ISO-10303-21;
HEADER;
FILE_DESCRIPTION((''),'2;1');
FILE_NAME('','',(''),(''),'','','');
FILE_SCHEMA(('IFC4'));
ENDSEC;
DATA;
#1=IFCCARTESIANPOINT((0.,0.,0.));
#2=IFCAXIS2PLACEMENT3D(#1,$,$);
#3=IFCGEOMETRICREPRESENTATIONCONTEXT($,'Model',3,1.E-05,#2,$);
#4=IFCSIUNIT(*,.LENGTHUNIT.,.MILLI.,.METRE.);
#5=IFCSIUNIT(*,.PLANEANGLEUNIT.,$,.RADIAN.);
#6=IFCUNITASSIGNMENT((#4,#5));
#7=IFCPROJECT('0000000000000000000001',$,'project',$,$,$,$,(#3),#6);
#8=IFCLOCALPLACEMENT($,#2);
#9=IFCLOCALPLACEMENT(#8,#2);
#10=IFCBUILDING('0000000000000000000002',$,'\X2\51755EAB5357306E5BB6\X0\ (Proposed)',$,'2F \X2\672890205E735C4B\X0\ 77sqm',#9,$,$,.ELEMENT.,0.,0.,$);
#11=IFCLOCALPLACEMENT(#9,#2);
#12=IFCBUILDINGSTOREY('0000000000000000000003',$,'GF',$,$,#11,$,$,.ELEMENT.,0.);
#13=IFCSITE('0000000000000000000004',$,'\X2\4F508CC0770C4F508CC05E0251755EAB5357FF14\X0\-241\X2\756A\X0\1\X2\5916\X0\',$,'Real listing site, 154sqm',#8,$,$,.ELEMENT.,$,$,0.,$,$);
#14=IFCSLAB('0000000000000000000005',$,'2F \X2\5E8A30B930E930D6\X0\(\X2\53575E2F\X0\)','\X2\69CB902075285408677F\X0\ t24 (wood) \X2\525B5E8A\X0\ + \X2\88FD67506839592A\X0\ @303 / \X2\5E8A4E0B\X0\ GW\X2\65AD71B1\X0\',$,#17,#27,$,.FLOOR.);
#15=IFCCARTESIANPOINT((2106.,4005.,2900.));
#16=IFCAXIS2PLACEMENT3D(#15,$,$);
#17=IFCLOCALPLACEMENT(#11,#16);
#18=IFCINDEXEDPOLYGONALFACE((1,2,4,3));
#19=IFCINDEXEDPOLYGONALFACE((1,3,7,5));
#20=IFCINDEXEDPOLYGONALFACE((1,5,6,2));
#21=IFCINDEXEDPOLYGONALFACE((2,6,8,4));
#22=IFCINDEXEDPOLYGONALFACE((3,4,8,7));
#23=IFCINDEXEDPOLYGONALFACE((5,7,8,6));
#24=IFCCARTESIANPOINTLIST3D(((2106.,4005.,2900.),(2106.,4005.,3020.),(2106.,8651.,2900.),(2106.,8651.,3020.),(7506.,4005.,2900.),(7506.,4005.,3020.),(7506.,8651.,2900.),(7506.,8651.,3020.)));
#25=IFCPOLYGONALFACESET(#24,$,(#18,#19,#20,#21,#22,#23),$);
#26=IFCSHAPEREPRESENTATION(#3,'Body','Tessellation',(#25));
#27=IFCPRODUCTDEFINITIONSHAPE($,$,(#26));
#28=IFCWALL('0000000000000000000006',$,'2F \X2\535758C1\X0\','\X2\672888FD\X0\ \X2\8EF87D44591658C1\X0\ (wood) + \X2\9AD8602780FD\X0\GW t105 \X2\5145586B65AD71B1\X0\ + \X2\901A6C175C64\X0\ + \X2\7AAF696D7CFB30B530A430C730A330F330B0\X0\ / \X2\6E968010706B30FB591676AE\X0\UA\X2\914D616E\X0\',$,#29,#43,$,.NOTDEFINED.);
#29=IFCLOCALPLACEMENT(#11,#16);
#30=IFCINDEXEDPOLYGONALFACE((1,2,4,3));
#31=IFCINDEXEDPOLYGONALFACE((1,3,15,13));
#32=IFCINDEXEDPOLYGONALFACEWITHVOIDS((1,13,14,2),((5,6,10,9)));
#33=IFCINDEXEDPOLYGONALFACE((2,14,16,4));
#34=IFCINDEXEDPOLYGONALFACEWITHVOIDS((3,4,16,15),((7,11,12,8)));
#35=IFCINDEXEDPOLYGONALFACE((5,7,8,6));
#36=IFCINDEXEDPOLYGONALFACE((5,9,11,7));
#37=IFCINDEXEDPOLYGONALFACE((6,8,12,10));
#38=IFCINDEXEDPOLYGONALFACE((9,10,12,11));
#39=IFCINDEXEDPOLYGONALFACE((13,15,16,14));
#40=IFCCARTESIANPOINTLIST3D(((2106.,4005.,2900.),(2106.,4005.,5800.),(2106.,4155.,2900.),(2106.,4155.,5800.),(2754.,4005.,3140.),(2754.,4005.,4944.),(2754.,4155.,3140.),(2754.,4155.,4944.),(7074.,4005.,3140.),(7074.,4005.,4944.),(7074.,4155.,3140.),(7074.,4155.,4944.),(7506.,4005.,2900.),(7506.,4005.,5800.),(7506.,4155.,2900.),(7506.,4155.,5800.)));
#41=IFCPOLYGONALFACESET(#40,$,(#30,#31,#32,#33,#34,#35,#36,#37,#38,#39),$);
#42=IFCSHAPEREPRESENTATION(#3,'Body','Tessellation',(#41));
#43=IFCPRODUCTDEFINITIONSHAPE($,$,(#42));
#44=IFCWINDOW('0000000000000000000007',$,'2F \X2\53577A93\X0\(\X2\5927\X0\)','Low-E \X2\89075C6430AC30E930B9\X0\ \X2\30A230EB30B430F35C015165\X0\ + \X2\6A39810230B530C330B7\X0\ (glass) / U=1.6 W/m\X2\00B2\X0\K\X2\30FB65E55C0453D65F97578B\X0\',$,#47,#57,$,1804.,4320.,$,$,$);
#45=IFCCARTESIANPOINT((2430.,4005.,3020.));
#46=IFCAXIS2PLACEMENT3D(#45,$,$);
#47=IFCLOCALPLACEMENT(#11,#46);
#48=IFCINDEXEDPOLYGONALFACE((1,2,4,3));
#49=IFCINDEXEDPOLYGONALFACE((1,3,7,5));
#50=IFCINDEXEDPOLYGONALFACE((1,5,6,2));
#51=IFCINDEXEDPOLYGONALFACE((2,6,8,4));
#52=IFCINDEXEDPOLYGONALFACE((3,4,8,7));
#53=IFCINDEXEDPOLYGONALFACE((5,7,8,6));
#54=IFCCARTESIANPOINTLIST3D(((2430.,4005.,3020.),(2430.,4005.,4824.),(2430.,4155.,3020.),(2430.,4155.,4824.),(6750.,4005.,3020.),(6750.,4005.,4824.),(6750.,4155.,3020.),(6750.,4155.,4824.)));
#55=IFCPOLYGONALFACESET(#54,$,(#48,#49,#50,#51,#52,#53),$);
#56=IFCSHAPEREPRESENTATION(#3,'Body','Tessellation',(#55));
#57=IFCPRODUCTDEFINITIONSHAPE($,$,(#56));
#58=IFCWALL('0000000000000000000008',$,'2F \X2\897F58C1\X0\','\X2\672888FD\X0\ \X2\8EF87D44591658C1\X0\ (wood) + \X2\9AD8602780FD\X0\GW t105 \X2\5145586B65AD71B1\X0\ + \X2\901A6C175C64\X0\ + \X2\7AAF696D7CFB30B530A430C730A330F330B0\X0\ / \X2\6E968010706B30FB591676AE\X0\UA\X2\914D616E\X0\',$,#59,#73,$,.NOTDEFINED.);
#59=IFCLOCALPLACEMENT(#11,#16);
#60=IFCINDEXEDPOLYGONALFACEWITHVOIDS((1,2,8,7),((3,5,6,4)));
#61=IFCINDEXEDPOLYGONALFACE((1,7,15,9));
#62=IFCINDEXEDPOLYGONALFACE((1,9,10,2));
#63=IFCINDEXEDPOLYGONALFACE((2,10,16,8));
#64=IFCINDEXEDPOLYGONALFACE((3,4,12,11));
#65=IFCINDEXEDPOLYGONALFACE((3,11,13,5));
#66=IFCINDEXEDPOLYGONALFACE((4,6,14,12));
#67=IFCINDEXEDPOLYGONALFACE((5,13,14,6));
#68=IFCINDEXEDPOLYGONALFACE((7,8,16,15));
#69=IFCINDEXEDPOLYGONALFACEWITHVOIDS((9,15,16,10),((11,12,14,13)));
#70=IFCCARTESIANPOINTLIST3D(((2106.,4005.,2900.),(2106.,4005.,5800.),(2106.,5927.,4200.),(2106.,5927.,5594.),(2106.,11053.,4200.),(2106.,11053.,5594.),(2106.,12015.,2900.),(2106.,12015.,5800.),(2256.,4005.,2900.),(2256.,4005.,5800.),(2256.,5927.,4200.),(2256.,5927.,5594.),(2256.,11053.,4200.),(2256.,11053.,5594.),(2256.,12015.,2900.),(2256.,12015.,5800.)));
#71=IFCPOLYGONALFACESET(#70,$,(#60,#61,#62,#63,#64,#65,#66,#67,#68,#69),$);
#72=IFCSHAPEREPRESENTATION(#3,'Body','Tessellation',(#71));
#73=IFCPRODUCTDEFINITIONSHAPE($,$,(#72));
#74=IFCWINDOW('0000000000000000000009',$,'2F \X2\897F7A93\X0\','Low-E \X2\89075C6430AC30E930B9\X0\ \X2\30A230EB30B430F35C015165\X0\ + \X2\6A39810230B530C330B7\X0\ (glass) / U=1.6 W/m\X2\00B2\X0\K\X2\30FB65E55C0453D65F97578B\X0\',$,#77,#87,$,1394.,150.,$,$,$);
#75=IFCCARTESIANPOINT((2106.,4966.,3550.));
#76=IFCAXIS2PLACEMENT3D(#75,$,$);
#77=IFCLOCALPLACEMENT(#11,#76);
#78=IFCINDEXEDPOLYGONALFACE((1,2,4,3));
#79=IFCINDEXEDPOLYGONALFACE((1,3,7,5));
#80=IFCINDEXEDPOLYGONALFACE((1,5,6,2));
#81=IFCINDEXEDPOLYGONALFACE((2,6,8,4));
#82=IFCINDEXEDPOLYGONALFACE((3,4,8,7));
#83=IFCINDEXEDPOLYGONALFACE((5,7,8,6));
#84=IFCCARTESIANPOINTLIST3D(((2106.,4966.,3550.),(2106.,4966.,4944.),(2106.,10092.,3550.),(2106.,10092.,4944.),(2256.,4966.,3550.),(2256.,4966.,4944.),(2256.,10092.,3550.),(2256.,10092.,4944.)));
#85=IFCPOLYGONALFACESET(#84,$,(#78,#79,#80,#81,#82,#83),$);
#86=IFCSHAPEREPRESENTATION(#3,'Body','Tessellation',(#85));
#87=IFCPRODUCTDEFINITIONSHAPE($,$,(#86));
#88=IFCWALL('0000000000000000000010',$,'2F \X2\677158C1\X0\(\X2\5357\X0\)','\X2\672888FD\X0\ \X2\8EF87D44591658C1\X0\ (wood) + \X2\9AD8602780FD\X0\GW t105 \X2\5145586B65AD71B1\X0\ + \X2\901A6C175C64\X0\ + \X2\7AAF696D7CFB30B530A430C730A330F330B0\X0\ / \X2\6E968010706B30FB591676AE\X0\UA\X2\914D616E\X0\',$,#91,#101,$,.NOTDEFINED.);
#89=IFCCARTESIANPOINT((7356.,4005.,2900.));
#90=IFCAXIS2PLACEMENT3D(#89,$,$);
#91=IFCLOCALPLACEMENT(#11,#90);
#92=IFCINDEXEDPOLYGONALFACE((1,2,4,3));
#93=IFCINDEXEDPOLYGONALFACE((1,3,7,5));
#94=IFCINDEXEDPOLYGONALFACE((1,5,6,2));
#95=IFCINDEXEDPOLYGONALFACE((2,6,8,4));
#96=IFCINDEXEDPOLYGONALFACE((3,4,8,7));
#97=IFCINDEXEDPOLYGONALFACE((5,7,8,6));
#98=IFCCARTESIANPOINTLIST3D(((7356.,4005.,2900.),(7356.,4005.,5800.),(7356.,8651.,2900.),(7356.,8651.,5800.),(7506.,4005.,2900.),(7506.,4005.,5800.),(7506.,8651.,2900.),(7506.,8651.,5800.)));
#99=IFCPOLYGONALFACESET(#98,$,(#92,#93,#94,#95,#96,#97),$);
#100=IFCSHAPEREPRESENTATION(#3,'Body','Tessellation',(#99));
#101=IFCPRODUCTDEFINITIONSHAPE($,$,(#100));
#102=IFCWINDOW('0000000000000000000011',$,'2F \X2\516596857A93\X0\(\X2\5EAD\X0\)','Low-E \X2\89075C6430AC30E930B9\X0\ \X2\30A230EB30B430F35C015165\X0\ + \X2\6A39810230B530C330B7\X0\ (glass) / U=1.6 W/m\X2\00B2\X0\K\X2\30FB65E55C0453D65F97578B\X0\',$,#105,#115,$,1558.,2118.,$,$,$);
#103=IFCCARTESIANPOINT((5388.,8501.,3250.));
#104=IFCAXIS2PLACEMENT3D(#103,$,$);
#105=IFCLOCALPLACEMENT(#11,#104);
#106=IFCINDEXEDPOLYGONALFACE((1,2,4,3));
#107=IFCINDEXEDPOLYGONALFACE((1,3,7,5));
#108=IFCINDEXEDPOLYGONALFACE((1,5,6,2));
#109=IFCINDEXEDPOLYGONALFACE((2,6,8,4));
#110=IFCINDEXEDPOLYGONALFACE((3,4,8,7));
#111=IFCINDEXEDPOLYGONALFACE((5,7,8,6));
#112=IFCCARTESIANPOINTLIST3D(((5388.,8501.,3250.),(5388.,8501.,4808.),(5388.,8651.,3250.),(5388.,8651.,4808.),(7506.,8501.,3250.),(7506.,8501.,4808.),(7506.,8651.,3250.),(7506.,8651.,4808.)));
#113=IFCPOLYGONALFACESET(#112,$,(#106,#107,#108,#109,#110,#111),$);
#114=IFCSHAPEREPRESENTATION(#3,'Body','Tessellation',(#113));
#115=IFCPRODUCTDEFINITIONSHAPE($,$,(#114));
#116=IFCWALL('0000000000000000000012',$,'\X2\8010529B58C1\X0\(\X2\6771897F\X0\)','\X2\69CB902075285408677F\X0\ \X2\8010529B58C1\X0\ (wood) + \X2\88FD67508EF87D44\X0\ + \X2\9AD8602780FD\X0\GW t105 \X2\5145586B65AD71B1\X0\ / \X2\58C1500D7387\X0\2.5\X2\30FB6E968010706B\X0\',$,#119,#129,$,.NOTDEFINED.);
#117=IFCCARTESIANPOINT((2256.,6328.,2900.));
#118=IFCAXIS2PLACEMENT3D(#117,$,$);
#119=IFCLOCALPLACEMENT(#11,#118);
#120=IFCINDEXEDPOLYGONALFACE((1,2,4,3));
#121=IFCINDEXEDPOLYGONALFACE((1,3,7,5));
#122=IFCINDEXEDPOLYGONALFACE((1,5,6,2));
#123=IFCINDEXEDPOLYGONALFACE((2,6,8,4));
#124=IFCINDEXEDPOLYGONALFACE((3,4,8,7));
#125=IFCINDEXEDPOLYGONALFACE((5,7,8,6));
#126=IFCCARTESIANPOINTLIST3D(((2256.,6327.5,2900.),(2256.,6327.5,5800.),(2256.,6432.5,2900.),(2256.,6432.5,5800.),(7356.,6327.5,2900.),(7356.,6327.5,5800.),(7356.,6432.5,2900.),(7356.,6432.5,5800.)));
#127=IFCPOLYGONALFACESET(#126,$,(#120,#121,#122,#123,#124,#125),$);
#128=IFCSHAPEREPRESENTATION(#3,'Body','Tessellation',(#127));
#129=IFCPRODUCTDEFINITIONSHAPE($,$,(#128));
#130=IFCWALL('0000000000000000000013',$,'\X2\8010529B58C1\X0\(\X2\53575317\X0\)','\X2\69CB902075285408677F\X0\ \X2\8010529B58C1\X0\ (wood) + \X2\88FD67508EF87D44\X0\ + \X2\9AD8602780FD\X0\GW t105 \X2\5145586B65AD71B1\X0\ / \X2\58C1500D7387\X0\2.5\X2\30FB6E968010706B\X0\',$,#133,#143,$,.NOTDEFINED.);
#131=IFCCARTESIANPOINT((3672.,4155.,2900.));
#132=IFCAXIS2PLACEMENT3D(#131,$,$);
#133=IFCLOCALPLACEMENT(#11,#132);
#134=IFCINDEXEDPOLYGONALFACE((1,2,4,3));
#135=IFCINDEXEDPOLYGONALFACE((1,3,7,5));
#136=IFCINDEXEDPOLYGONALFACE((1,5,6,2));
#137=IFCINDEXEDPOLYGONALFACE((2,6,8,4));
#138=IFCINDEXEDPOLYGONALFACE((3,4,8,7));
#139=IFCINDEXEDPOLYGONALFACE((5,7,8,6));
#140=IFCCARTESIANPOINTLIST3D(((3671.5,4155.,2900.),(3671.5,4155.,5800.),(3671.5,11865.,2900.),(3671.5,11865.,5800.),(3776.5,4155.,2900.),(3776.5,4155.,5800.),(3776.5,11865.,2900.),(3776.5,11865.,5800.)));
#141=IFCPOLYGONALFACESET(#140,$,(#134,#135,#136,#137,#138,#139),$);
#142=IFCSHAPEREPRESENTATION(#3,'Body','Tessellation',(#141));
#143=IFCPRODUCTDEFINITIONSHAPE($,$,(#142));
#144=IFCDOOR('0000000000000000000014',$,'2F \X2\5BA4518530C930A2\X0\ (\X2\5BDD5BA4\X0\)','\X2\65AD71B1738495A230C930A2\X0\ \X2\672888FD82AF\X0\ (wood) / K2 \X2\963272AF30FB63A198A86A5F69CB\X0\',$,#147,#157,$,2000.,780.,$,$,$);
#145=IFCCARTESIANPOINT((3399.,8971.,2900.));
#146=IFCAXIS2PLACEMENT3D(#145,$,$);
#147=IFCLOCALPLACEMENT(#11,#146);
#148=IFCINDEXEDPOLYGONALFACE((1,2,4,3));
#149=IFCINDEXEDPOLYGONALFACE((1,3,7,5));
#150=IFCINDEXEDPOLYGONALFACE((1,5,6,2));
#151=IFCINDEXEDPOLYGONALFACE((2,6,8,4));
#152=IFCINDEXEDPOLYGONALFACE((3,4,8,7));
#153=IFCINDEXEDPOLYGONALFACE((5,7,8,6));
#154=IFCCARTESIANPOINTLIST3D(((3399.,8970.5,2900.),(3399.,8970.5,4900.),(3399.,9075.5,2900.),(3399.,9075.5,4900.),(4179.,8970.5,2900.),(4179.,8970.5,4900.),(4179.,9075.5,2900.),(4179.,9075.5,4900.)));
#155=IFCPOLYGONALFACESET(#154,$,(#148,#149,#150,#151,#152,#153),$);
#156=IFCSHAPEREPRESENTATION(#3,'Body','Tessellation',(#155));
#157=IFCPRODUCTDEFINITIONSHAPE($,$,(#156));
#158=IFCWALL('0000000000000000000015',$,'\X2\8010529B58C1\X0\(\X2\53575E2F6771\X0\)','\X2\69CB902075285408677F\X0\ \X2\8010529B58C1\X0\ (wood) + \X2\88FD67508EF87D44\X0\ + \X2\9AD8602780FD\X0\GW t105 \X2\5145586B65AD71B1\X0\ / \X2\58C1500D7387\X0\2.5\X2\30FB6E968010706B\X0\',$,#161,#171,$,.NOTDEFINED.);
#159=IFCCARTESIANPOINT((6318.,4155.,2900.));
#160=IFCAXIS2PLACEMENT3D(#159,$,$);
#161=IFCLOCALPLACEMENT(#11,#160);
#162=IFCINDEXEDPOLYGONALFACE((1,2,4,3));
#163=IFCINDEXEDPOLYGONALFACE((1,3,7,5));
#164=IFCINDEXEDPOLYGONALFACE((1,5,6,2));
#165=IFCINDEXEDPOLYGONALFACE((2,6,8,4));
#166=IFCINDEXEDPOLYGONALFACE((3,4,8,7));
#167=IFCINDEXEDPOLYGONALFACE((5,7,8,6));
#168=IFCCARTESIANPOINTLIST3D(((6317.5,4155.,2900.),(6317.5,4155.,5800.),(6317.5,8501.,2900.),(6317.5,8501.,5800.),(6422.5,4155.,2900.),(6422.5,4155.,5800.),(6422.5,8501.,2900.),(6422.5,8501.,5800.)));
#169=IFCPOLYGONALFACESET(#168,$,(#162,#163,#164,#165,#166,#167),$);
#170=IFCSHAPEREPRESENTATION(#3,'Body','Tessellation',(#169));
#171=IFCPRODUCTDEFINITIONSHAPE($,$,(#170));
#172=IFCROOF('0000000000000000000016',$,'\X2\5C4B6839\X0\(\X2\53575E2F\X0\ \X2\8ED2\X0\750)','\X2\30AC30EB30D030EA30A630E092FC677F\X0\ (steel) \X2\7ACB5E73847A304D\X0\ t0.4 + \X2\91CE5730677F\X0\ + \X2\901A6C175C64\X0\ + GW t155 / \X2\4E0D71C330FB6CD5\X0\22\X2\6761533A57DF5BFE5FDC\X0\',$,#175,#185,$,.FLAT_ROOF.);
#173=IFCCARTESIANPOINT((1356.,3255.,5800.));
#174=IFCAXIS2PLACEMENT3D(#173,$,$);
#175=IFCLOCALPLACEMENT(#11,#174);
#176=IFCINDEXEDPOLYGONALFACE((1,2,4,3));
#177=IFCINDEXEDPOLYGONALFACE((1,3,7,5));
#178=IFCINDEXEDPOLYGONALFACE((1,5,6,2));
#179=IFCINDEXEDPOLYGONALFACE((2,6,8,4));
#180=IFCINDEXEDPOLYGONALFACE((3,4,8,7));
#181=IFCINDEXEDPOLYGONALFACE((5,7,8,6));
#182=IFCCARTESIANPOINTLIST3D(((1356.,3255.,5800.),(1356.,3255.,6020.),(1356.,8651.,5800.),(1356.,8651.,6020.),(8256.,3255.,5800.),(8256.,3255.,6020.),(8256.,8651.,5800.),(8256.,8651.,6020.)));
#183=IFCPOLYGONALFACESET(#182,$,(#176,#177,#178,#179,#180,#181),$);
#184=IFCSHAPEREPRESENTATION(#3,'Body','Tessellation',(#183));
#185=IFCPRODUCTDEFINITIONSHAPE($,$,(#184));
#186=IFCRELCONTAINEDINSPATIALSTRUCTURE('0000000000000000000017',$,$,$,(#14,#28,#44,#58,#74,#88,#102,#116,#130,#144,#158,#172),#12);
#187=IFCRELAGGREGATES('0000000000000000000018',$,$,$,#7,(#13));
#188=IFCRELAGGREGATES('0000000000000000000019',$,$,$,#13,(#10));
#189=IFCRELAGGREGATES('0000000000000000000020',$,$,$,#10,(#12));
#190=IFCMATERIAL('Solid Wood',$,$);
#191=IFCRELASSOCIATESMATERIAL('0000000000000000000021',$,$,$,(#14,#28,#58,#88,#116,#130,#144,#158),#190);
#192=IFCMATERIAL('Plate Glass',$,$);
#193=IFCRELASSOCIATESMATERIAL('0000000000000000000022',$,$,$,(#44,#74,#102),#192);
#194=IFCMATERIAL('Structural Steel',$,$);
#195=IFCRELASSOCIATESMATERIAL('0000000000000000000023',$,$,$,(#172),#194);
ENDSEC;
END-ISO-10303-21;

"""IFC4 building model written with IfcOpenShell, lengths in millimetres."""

from ifc_helpers import new_model, si_unit, frame, frame_2d, origin, place, context, project, spatial, rectangle, extrude, material, element, fill, save


model = new_model("IFC4")

# Units and contexts
model_context = context("Model", 3, precision=1e-05, world=origin())
ifc_project = project(units=[si_unit("LENGTHUNIT", "METRE", prefix="MILLI"), si_unit("PLANEANGLEUNIT", "RADIAN")], contexts=[model_context])

# Site, building, storey
site_placement = place(None, origin())
site = spatial("IfcSite", under=ifc_project, at=site_placement, Name="佐賀県佐賀市兵庫南４-241番1外", ObjectType="Real listing site, 154sqm", CompositionType="ELEMENT", RefElevation=0.0)
building_placement = place(site_placement, origin())
building = spatial("IfcBuilding", under=site, at=building_placement, Name="兵庫南の家 (Proposed)", ObjectType="2F 木造平屋 77sqm", CompositionType="ELEMENT", ElevationOfRefHeight=0.0, ElevationOfTerrain=0.0)
storey_placement = place(building_placement, origin())
storey = spatial("IfcBuildingStorey", under=building, at=storey_placement, Name="GF", CompositionType="ELEMENT", Elevation=0.0)

# Slab
ifc_material_1 = material(Name="Solid Wood")
slab_placement = place(storey_placement, frame((2106.0, 4005.0, 2900.0)))
element("IfcSlab", 1, at=slab_placement, inside=storey, material=ifc_material_1, Name="2F 床スラブ(南帯)", Description="構造用合板 t24 (wood) 剛床 + 製材根太 @303 / 床下 GW断熱", PredefinedType="FLOOR", context=model_context, shape_type="SweptSolid", body=[
    extrude(rectangle(XDim=5400.0, YDim=4646.0, at=frame_2d((2700.0, 2323.0))), frame((2106.0, 4005.0, 2900.0)), (0.0, 0.0, 1.0), 120.0),
])

# Walls, openings, windows
wall_1_placement = place(storey_placement, frame((2106.0, 4005.0, 2900.0)))
wall_1 = element("IfcWall", 2, at=wall_1_placement, inside=storey, material=ifc_material_1, Name="2F 南壁", Description="木製 軸組外壁 (wood) + 高性能GW t105 充填断熱 + 通気層 + 窯業系サイディング / 準耐火・外皮UA配慮", PredefinedType="NOTDEFINED", context=model_context, shape_type="SweptSolid", body=[
    extrude(rectangle(XDim=5400.0, YDim=150.0, at=frame_2d((2700.0, 75.0))), frame((2106.0, 4005.0, 2900.0)), (0.0, 0.0, 1.0), 2900.0),
])
opening_1_placement = place(storey_placement, frame((2430.0, 4005.0, 3020.0)))
opening_1 = element("IfcOpeningElement", 3, at=opening_1_placement, cuts=wall_1, PredefinedType="NOTDEFINED", context=model_context, shape_type="SweptSolid", body=[
    extrude(rectangle(XDim=4320.0, YDim=150.0, at=frame_2d((2160.0, 75.0))), frame((2430.0, 4005.0, 3020.0)), (0.0, 0.0, 1.0), 1804.0),
])
ifc_material_2 = material(Name="Plate Glass")
window_1_placement = place(storey_placement, frame((2430.0, 4005.0, 3020.0)))
window_1 = element("IfcWindow", 4, at=window_1_placement, inside=storey, material=ifc_material_2, Name="2F 南窓(大)", Description="Low-E 複層ガラス アルゴン封入 + 樹脂サッシ (glass) / U=1.6 W/m²K・日射取得型", OverallHeight=1804.0, OverallWidth=4320.0, context=model_context, shape_type="SweptSolid", body=[
    extrude(rectangle(XDim=4320.0, YDim=150.0, at=frame_2d((2160.0, 75.0))), frame((2430.0, 4005.0, 3020.0)), (0.0, 0.0, 1.0), 1804.0),
])
fill(opening_1, window_1)
wall_2_placement = place(storey_placement, frame((2106.0, 4005.0, 2900.0)))
wall_2 = element("IfcWall", 5, at=wall_2_placement, inside=storey, material=ifc_material_1, Name="2F 西壁", Description="木製 軸組外壁 (wood) + 高性能GW t105 充填断熱 + 通気層 + 窯業系サイディング / 準耐火・外皮UA配慮", PredefinedType="NOTDEFINED", context=model_context, shape_type="SweptSolid", body=[
    extrude(rectangle(XDim=150.0, YDim=8010.0, at=frame_2d((75.0, 4005.0))), frame((2106.0, 4005.0, 2900.0)), (0.0, 0.0, 1.0), 2900.0),
])
opening_2_placement = place(storey_placement, frame((2106.0, 4966.0, 3550.0)))
opening_2 = element("IfcOpeningElement", 6, at=opening_2_placement, cuts=wall_2, PredefinedType="NOTDEFINED", context=model_context, shape_type="SweptSolid", body=[
    extrude(rectangle(XDim=150.0, YDim=5126.0, at=frame_2d((75.0, 2563.0))), frame((2106.0, 4966.0, 3550.0)), (0.0, 0.0, 1.0), 1394.0),
])
window_2_placement = place(storey_placement, frame((2106.0, 4966.0, 3550.0)))
window_2 = element("IfcWindow", 7, at=window_2_placement, inside=storey, material=ifc_material_2, Name="2F 西窓", Description="Low-E 複層ガラス アルゴン封入 + 樹脂サッシ (glass) / U=1.6 W/m²K・日射取得型", OverallHeight=1394.0, OverallWidth=150.0, context=model_context, shape_type="SweptSolid", body=[
    extrude(rectangle(XDim=150.0, YDim=5126.0, at=frame_2d((75.0, 2563.0))), frame((2106.0, 4966.0, 3550.0)), (0.0, 0.0, 1.0), 1394.0),
])
fill(opening_2, window_2)
wall_3_placement = place(storey_placement, frame((7356.0, 4005.0, 2900.0)))
wall_3 = element("IfcWall", 8, at=wall_3_placement, inside=storey, material=ifc_material_1, Name="2F 東壁(南)", Description="木製 軸組外壁 (wood) + 高性能GW t105 充填断熱 + 通気層 + 窯業系サイディング / 準耐火・外皮UA配慮", PredefinedType="NOTDEFINED", context=model_context, shape_type="SweptSolid", body=[
    extrude(rectangle(XDim=150.0, YDim=4646.0, at=frame_2d((75.0, 2323.0))), frame((7356.0, 4005.0, 2900.0)), (0.0, 0.0, 1.0), 2900.0),
])
opening_3_placement = place(storey_placement, frame((5388.0, 8501.0, 3250.0)))
opening_3 = element("IfcOpeningElement", 9, at=opening_3_placement, cuts=wall_3, PredefinedType="NOTDEFINED", context=model_context, shape_type="SweptSolid", body=[
    extrude(rectangle(XDim=2118.0, YDim=150.0, at=frame_2d((1059.0, 75.0))), frame((5388.0, 8501.0, 3250.0)), (0.0, 0.0, 1.0), 1558.0),
])
window_3_placement = place(storey_placement, frame((5388.0, 8501.0, 3250.0)))
window_3 = element("IfcWindow", 10, at=window_3_placement, inside=storey, material=ifc_material_2, Name="2F 入隅窓(庭)", Description="Low-E 複層ガラス アルゴン封入 + 樹脂サッシ (glass) / U=1.6 W/m²K・日射取得型", OverallHeight=1558.0, OverallWidth=2118.0, context=model_context, shape_type="SweptSolid", body=[
    extrude(rectangle(XDim=2118.0, YDim=150.0, at=frame_2d((1059.0, 75.0))), frame((5388.0, 8501.0, 3250.0)), (0.0, 0.0, 1.0), 1558.0),
])
fill(opening_3, window_3)

# Wall
wall_4_placement = place(storey_placement, frame((2256.0, 6328.0, 2900.0)))
element("IfcWall", 11, at=wall_4_placement, inside=storey, material=ifc_material_1, Name="耐力壁(東西)", Description="構造用合板 耐力壁 (wood) + 製材軸組 + 高性能GW t105 充填断熱 / 壁倍率2.5・準耐火", PredefinedType="NOTDEFINED", context=model_context, shape_type="SweptSolid", body=[
    extrude(rectangle(XDim=5100.0, YDim=105.0, at=frame_2d((2550.0, 52.0))), frame((2256.0, 6328.0, 2900.0)), (0.0, 0.0, 1.0), 2900.0),
])

# Wall, opening, door
wall_5_placement = place(storey_placement, frame((3672.0, 4155.0, 2900.0)))
wall_5 = element("IfcWall", 12, at=wall_5_placement, inside=storey, material=ifc_material_1, Name="耐力壁(南北)", Description="構造用合板 耐力壁 (wood) + 製材軸組 + 高性能GW t105 充填断熱 / 壁倍率2.5・準耐火", PredefinedType="NOTDEFINED", context=model_context, shape_type="SweptSolid", body=[
    extrude(rectangle(XDim=105.0, YDim=7710.0, at=frame_2d((52.0, 3855.0))), frame((3672.0, 4155.0, 2900.0)), (0.0, 0.0, 1.0), 2900.0),
])
opening_4_placement = place(storey_placement, frame((3399.0, 8971.0, 2900.0)))
opening_4 = element("IfcOpeningElement", 13, at=opening_4_placement, cuts=wall_5, PredefinedType="NOTDEFINED", context=model_context, shape_type="SweptSolid", body=[
    extrude(rectangle(XDim=780.0, YDim=105.0, at=frame_2d((390.0, 52.0))), frame((3399.0, 8971.0, 2900.0)), (0.0, 0.0, 1.0), 2000.0),
])
door_placement = place(storey_placement, frame((3399.0, 8971.0, 2900.0)))
door = element("IfcDoor", 14, at=door_placement, inside=storey, material=ifc_material_1, Name="2F 室内ドア (寝室)", Description="断熱玄関ドア 木製芯 (wood) / K2 防犯・採風機構", OverallHeight=2000.0, OverallWidth=780.0, context=model_context, shape_type="SweptSolid", body=[
    extrude(rectangle(XDim=780.0, YDim=105.0, at=frame_2d((390.0, 52.0))), frame((3399.0, 8971.0, 2900.0)), (0.0, 0.0, 1.0), 2000.0),
])
fill(opening_4, door)

# Wall
wall_6_placement = place(storey_placement, frame((6318.0, 4155.0, 2900.0)))
element("IfcWall", 15, at=wall_6_placement, inside=storey, material=ifc_material_1, Name="耐力壁(南帯東)", Description="構造用合板 耐力壁 (wood) + 製材軸組 + 高性能GW t105 充填断熱 / 壁倍率2.5・準耐火", PredefinedType="NOTDEFINED", context=model_context, shape_type="SweptSolid", body=[
    extrude(rectangle(XDim=105.0, YDim=4346.0, at=frame_2d((52.0, 2173.0))), frame((6318.0, 4155.0, 2900.0)), (0.0, 0.0, 1.0), 2900.0),
])

# Roof
ifc_material_3 = material(Name="Structural Steel")
for number, where, name in (
    (16, (1356.0, 3255.0, 5800.0), "屋根(南帯 軒750)"),
):
    element("IfcRoof", number, at=place(storey_placement, frame(where)), inside=storey, material=ifc_material_3, Name=name, Description="ガルバリウム鋼板 (steel) 立平葺き t0.4 + 野地板 + 通気層 + GW t155 / 不燃・法22条区域対応", PredefinedType="FLAT_ROOF", context=model_context, shape_type="SweptSolid", body=[
        extrude(rectangle(XDim=6900.0, YDim=5396.0, at=frame_2d((3450.0, 2698.0))), frame((1356.0, 3255.0, 5800.0)), (0.0, 0.0, 1.0), 220.0),
    ])

save(model, "model.ifc")
